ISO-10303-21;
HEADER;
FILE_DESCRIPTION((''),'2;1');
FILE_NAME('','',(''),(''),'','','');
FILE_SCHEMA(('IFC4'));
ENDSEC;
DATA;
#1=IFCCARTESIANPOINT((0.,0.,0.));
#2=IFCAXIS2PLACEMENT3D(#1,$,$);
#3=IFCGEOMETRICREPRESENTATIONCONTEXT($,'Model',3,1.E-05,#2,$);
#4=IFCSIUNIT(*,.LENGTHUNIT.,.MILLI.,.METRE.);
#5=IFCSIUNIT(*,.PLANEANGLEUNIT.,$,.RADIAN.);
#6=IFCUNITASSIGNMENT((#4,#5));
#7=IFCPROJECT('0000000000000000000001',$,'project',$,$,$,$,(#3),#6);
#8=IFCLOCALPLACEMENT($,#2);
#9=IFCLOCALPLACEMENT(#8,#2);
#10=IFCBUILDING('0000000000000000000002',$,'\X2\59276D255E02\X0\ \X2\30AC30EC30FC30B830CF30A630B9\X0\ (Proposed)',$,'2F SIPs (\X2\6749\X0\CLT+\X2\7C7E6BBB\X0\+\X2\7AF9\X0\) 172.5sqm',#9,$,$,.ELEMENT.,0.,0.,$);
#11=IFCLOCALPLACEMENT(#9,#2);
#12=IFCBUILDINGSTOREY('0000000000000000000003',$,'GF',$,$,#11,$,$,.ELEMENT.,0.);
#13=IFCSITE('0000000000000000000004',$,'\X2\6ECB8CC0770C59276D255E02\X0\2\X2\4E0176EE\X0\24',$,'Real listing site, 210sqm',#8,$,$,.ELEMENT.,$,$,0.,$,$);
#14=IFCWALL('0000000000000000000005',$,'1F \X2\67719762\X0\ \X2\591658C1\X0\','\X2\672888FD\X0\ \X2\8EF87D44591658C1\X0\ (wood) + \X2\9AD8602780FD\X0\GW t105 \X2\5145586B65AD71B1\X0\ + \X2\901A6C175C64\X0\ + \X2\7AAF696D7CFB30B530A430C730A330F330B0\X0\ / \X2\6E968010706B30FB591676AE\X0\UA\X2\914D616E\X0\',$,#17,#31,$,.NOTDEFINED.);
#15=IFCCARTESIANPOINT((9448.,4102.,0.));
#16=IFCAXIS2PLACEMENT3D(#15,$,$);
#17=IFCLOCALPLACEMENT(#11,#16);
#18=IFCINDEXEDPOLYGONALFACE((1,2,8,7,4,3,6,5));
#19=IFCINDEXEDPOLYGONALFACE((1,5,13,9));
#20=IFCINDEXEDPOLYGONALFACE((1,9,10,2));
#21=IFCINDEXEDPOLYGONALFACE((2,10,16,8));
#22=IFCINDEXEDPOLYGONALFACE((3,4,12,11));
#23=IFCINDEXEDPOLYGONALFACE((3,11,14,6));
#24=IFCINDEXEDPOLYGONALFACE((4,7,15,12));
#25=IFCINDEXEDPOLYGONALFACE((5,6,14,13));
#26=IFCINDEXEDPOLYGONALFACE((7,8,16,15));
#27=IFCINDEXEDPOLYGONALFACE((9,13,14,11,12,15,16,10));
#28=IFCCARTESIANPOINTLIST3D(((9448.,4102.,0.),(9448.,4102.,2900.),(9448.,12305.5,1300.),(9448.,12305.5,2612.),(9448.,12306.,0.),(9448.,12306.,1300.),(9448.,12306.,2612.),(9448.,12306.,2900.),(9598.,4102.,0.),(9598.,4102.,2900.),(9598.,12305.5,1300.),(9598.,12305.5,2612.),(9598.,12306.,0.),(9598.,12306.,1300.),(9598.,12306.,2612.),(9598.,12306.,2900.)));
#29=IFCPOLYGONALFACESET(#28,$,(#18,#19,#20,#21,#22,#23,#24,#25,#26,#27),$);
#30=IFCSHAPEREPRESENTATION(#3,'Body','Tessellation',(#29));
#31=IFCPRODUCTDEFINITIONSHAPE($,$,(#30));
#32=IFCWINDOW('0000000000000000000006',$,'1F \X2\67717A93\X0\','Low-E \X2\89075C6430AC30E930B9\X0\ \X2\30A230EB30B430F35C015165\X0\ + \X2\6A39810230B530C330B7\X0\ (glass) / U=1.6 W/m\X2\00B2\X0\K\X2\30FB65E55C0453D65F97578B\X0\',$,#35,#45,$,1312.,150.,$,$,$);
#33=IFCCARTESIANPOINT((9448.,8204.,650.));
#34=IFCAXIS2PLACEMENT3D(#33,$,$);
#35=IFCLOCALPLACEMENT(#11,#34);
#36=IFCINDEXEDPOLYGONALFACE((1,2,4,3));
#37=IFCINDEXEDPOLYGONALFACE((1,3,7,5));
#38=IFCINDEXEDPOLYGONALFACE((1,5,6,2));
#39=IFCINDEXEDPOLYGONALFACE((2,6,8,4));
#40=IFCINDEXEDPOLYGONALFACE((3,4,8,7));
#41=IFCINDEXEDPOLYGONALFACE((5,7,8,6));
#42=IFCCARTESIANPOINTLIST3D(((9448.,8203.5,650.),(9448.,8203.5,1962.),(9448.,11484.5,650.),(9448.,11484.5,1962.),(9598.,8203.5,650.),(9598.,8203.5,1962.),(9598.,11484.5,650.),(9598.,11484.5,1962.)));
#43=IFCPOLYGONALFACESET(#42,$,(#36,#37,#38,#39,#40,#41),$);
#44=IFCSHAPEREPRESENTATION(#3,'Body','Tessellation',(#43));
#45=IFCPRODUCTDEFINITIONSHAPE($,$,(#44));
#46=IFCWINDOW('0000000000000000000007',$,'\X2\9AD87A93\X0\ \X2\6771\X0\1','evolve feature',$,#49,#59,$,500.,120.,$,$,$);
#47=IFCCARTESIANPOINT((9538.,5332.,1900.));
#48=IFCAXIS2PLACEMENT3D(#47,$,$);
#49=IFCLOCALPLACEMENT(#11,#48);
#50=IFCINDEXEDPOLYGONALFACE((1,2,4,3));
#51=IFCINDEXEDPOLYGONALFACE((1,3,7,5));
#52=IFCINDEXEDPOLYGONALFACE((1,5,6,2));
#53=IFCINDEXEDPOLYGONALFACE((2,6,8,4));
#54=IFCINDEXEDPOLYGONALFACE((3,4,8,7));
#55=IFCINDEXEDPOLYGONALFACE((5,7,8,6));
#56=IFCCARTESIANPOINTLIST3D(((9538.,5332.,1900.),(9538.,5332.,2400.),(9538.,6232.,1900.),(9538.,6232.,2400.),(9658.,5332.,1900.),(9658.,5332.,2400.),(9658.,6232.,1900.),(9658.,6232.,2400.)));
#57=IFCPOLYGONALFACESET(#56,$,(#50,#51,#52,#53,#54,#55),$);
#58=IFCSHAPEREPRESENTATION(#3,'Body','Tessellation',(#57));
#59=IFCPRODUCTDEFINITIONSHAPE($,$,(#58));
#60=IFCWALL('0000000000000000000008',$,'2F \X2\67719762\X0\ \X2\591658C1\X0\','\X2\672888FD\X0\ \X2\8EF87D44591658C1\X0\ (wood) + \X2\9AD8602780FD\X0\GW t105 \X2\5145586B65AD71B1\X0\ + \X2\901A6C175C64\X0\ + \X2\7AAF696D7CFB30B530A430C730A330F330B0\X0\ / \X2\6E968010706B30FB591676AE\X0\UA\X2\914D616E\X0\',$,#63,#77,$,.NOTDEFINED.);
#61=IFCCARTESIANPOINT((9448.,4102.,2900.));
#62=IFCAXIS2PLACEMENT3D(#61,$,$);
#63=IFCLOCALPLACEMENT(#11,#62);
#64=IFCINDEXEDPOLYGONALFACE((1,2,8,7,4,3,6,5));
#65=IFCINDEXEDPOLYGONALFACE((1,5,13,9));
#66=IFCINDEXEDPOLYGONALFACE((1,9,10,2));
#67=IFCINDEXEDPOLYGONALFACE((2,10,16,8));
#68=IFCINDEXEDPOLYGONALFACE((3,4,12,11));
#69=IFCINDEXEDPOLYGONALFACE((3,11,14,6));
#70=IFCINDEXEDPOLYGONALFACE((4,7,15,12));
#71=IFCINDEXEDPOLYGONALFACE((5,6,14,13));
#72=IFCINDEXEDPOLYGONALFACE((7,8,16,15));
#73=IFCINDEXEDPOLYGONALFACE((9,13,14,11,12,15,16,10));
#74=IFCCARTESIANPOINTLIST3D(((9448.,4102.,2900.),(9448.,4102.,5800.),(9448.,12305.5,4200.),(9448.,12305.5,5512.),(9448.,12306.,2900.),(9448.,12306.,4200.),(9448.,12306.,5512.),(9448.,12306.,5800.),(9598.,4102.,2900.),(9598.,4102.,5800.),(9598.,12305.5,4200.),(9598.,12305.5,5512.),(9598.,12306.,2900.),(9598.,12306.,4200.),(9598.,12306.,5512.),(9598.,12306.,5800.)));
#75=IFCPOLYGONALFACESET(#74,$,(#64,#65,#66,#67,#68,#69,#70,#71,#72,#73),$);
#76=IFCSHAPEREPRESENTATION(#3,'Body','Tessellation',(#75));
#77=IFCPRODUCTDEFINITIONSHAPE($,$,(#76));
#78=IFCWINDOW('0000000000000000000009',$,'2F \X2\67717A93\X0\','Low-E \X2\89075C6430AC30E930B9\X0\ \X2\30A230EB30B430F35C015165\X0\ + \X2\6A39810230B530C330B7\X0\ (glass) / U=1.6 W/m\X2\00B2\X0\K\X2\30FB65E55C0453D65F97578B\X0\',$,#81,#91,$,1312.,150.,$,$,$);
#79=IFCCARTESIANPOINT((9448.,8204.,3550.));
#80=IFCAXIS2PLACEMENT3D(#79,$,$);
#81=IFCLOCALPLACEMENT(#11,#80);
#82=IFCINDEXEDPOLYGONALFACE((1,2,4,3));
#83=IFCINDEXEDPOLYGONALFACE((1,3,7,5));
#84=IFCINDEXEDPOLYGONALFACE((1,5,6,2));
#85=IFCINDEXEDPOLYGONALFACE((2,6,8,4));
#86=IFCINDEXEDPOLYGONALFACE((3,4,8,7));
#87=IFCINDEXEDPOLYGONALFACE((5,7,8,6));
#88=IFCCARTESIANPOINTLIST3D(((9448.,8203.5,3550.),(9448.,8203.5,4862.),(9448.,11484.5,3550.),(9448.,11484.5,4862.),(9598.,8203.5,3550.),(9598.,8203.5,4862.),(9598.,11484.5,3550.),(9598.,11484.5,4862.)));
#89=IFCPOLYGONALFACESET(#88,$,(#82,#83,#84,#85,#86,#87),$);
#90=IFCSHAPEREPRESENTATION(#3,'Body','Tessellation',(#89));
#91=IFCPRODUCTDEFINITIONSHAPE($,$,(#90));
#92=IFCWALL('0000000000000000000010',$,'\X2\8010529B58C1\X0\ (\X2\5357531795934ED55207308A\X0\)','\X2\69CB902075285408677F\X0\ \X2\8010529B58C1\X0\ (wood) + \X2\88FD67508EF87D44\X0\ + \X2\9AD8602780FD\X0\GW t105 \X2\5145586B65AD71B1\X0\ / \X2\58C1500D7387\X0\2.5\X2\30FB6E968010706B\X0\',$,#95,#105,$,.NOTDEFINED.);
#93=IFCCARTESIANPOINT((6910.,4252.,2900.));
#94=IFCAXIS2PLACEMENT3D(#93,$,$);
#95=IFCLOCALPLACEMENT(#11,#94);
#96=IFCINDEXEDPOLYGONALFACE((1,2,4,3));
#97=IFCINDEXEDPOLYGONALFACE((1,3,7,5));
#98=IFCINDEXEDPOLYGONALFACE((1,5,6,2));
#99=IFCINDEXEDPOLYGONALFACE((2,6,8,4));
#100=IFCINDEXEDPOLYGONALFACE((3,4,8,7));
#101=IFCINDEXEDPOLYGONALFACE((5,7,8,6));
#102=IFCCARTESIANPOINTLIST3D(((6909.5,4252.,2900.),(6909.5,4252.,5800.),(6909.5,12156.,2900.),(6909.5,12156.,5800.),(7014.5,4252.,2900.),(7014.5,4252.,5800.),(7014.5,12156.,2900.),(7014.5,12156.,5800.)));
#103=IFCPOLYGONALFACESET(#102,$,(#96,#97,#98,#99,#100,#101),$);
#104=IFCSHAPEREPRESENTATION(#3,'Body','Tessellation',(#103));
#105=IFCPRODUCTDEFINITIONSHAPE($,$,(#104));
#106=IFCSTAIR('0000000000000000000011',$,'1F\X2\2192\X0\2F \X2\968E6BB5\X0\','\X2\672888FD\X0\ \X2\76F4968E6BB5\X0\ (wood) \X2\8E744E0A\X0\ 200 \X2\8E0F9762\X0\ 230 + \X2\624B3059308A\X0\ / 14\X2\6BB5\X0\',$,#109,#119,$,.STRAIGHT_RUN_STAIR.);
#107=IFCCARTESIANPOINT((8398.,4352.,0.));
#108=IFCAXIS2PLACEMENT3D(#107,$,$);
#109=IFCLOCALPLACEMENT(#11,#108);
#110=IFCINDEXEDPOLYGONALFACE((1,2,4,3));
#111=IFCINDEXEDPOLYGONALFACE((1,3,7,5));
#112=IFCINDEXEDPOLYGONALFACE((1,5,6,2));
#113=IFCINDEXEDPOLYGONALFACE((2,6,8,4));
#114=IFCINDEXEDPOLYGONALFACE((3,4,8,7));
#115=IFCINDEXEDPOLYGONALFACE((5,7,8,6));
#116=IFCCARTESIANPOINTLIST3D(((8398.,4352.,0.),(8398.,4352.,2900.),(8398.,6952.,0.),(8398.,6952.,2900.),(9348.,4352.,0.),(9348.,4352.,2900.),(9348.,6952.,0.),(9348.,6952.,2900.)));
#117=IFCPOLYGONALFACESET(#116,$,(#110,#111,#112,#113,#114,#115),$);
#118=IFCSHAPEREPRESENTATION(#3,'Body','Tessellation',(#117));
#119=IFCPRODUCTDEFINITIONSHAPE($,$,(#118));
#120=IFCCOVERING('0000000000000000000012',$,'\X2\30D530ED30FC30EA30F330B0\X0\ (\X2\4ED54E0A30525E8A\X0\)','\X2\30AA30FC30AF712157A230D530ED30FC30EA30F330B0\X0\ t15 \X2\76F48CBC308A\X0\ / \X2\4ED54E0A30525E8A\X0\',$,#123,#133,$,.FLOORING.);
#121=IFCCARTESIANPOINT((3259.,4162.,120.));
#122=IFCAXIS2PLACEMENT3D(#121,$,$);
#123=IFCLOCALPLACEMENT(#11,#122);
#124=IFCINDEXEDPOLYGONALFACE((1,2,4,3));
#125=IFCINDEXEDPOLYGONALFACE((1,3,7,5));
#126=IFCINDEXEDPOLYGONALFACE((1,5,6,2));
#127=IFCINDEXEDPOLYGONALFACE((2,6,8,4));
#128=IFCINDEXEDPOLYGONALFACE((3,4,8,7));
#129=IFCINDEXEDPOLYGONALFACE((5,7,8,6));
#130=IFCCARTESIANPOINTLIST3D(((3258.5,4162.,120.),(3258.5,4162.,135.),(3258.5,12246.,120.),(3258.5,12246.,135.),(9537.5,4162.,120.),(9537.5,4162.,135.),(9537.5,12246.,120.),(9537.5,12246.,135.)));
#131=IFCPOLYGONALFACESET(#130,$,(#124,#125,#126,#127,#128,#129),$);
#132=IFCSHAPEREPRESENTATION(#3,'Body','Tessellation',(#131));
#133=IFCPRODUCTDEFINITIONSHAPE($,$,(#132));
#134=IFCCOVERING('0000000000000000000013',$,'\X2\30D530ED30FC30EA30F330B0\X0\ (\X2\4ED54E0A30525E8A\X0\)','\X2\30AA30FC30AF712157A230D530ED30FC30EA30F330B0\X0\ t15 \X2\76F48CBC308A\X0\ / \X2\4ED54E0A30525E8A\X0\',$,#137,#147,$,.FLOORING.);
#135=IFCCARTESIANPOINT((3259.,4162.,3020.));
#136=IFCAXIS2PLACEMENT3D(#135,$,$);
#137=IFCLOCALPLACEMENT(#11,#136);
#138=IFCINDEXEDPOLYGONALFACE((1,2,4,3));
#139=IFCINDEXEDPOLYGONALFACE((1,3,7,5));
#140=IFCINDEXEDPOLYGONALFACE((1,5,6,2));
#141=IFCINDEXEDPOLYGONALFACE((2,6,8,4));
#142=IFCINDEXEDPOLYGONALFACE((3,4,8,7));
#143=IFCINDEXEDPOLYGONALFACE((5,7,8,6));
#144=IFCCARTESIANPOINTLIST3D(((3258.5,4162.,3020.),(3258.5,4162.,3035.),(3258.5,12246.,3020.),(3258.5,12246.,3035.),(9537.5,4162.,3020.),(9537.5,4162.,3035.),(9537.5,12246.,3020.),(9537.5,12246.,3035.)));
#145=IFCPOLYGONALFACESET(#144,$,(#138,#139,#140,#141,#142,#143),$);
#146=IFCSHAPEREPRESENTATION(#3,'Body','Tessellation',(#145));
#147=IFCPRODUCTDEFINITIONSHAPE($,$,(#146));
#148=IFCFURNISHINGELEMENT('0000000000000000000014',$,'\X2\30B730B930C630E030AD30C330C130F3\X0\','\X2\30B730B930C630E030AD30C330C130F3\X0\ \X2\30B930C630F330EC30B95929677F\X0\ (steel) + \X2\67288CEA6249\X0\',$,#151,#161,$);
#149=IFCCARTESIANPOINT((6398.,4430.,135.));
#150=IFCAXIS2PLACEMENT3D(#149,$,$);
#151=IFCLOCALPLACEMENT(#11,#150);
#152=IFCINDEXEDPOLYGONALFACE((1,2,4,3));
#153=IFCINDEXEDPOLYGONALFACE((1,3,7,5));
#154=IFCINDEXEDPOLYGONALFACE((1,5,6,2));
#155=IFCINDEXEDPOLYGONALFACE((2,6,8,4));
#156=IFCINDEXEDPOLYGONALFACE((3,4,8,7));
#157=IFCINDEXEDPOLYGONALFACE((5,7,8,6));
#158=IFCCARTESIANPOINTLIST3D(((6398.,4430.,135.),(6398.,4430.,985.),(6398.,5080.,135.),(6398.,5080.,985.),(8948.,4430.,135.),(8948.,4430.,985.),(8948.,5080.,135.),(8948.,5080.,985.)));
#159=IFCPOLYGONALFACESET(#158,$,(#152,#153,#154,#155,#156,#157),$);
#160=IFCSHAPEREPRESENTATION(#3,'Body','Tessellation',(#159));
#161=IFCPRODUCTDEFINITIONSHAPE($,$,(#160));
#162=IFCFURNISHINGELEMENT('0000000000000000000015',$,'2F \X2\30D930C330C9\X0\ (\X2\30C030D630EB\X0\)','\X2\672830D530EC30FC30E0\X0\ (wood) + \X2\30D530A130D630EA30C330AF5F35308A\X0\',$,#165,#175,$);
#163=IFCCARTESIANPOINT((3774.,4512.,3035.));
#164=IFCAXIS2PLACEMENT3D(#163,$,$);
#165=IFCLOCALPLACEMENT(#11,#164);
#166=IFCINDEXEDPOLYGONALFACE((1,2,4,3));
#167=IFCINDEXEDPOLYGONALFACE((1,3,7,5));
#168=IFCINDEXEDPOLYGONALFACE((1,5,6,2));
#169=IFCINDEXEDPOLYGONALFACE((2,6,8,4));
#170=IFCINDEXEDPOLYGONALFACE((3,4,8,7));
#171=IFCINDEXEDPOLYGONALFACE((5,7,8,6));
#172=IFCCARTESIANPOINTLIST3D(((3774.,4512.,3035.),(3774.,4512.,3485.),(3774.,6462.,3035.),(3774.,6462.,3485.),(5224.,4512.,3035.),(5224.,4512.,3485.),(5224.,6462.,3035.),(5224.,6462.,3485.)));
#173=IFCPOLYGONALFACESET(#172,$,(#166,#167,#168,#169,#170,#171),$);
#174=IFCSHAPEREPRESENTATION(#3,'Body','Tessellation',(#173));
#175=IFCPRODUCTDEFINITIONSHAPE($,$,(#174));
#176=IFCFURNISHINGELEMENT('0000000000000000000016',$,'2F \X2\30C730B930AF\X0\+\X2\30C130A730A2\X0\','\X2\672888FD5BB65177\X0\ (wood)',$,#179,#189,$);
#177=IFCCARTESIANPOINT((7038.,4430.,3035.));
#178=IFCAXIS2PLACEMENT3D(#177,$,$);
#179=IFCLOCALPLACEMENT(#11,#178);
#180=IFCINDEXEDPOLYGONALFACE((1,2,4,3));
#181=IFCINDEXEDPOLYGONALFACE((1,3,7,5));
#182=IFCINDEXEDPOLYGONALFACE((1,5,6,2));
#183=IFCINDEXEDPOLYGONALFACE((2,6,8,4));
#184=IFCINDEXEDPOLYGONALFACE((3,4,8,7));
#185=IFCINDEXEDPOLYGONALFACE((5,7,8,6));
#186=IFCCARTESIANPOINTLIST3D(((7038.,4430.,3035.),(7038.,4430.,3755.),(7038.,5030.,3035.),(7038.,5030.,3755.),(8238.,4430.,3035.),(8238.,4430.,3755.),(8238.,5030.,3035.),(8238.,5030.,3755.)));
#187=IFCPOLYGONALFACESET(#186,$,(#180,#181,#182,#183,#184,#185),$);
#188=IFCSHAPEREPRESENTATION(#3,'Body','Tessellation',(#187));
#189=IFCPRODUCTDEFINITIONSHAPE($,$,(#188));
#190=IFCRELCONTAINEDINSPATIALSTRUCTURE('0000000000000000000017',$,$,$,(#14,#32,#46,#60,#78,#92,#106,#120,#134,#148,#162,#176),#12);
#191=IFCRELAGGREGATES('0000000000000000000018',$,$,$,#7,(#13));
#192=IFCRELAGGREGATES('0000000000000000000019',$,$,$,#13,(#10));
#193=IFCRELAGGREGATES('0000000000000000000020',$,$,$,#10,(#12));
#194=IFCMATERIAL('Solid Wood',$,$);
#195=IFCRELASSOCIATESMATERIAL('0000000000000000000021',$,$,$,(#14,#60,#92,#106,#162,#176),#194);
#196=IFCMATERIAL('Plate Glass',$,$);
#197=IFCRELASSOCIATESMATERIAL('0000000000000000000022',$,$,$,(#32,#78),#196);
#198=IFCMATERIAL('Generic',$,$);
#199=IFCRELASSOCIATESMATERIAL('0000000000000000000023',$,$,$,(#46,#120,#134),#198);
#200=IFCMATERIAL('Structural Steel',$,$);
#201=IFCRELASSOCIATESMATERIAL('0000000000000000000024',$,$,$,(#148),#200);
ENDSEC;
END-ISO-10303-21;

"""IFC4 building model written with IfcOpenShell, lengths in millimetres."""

from ifc_helpers import new_model, si_unit, frame, frame_2d, origin, place, context, project, spatial, rectangle, extrude, material, element, fill, save


model = new_model("IFC4")

# Units and contexts
model_context = context("Model", 3, precision=1e-05, world=origin())
ifc_project = project(units=[si_unit("LENGTHUNIT", "METRE", prefix="MILLI"), si_unit("PLANEANGLEUNIT", "RADIAN")], contexts=[model_context])

# Site, building, storey
site_placement = place(None, origin())
site = spatial("IfcSite", under=ifc_project, at=site_placement, Name="滋賀県大津市2丁目24", ObjectType="Real listing site, 210sqm", CompositionType="ELEMENT", RefElevation=0.0)
building_placement = place(site_placement, origin())
building = spatial("IfcBuilding", under=site, at=building_placement, Name="大津市 ガレージハウス (Proposed)", ObjectType="2F SIPs (杉CLT+籾殻+竹) 172.5sqm", CompositionType="ELEMENT", ElevationOfRefHeight=0.0, ElevationOfTerrain=0.0)
storey_placement = place(building_placement, origin())
storey = spatial("IfcBuildingStorey", under=building, at=storey_placement, Name="GF", CompositionType="ELEMENT", Elevation=0.0)

# Shared definitions
ifc_material_1 = material(Name="Solid Wood")

# Wall, openings, windows
wall_1_placement = place(storey_placement, frame((9448.0, 4102.0, 0.0)))
wall_1 = element("IfcWall", 1, at=wall_1_placement, inside=storey, material=ifc_material_1, Name="1F 東面 外壁", Description="木製 軸組外壁 (wood) + 高性能GW t105 充填断熱 + 通気層 + 窯業系サイディング / 準耐火・外皮UA配慮", PredefinedType="NOTDEFINED", context=model_context, shape_type="SweptSolid", body=[
    extrude(rectangle(XDim=150.0, YDim=8204.0, at=frame_2d((75.0, 4102.0))), frame((9448.0, 4102.0, 0.0)), (0.0, 0.0, 1.0), 2900.0),
])
opening_1_placement = place(storey_placement, frame((9448.0, 8204.0, 650.0)))
opening_1 = element("IfcOpeningElement", 2, at=opening_1_placement, cuts=wall_1, PredefinedType="NOTDEFINED", context=model_context, shape_type="SweptSolid", body=[
    extrude(rectangle(XDim=150.0, YDim=3281.0, at=frame_2d((75.0, 1640.0))), frame((9448.0, 8204.0, 650.0)), (0.0, 0.0, 1.0), 1312.0),
])
opening_2_placement = place(storey_placement, frame((9538.0, 5332.0, 1900.0)))
opening_2 = element("IfcOpeningElement", 3, at=opening_2_placement, cuts=wall_1, PredefinedType="NOTDEFINED", context=model_context, shape_type="SweptSolid", body=[
    extrude(rectangle(XDim=120.0, YDim=900.0, at=frame_2d((60.0, 450.0))), frame((9538.0, 5332.0, 1900.0)), (0.0, 0.0, 1.0), 500.0),
])
ifc_material_2 = material(Name="Plate Glass")
window_1_placement = place(storey_placement, frame((9448.0, 8204.0, 650.0)))
window_1 = element("IfcWindow", 4, at=window_1_placement, inside=storey, material=ifc_material_2, Name="1F 東窓", Description="Low-E 複層ガラス アルゴン封入 + 樹脂サッシ (glass) / U=1.6 W/m²K・日射取得型", OverallHeight=1312.0, OverallWidth=150.0, context=model_context, shape_type="SweptSolid", body=[
    extrude(rectangle(XDim=150.0, YDim=3281.0, at=frame_2d((75.0, 1640.0))), frame((9448.0, 8204.0, 650.0)), (0.0, 0.0, 1.0), 1312.0),
])
fill(opening_1, window_1)
ifc_material_3 = material(Name="Generic")
window_2_placement = place(storey_placement, frame((9538.0, 5332.0, 1900.0)))
window_2 = element("IfcWindow", 5, at=window_2_placement, inside=storey, material=ifc_material_3, Name="高窓 東1", Description="evolve feature", OverallHeight=500.0, OverallWidth=120.0, context=model_context, shape_type="SweptSolid", body=[
    extrude(rectangle(XDim=120.0, YDim=900.0, at=frame_2d((60.0, 450.0))), frame((9538.0, 5332.0, 1900.0)), (0.0, 0.0, 1.0), 500.0),
])
fill(opening_2, window_2)

# Wall, opening, window
wall_2_placement = place(storey_placement, frame((9448.0, 4102.0, 2900.0)))
wall_2 = element("IfcWall", 6, at=wall_2_placement, inside=storey, material=ifc_material_1, Name="2F 東面 外壁", Description="木製 軸組外壁 (wood) + 高性能GW t105 充填断熱 + 通気層 + 窯業系サイディング / 準耐火・外皮UA配慮", PredefinedType="NOTDEFINED", context=model_context, shape_type="SweptSolid", body=[
    extrude(rectangle(XDim=150.0, YDim=8204.0, at=frame_2d((75.0, 4102.0))), frame((9448.0, 4102.0, 2900.0)), (0.0, 0.0, 1.0), 2900.0),
])
opening_3_placement = place(storey_placement, frame((9448.0, 8204.0, 3550.0)))
opening_3 = element("IfcOpeningElement", 7, at=opening_3_placement, cuts=wall_2, PredefinedType="NOTDEFINED", context=model_context, shape_type="SweptSolid", body=[
    extrude(rectangle(XDim=150.0, YDim=3281.0, at=frame_2d((75.0, 1640.0))), frame((9448.0, 8204.0, 3550.0)), (0.0, 0.0, 1.0), 1312.0),
])
window_3_placement = place(storey_placement, frame((9448.0, 8204.0, 3550.0)))
window_3 = element("IfcWindow", 8, at=window_3_placement, inside=storey, material=ifc_material_2, Name="2F 東窓", Description="Low-E 複層ガラス アルゴン封入 + 樹脂サッシ (glass) / U=1.6 W/m²K・日射取得型", OverallHeight=1312.0, OverallWidth=150.0, context=model_context, shape_type="SweptSolid", body=[
    extrude(rectangle(XDim=150.0, YDim=3281.0, at=frame_2d((75.0, 1640.0))), frame((9448.0, 8204.0, 3550.0)), (0.0, 0.0, 1.0), 1312.0),
])
fill(opening_3, window_3)

# Wall
wall_3_placement = place(storey_placement, frame((6910.0, 4252.0, 2900.0)))
element("IfcWall", 9, at=wall_3_placement, inside=storey, material=ifc_material_1, Name="耐力壁 (南北間仕切り)", Description="構造用合板 耐力壁 (wood) + 製材軸組 + 高性能GW t105 充填断熱 / 壁倍率2.5・準耐火", PredefinedType="NOTDEFINED", context=model_context, shape_type="SweptSolid", body=[
    extrude(rectangle(XDim=105.0, YDim=7904.0, at=frame_2d((52.0, 3952.0))), frame((6910.0, 4252.0, 2900.0)), (0.0, 0.0, 1.0), 2900.0),
])

# Stair
stair_placement = place(storey_placement, frame((8398.0, 4352.0, 0.0)))
element("IfcStair", 10, at=stair_placement, inside=storey, material=ifc_material_1, Name="1F→2F 階段", Description="木製 直階段 (wood) 蹴上 200 踏面 230 + 手すり / 14段", PredefinedType="STRAIGHT_RUN_STAIR", context=model_context, shape_type="SweptSolid", body=[
    extrude(rectangle(XDim=950.0, YDim=2600.0, at=frame_2d((475.0, 1300.0))), frame((8398.0, 4352.0, 0.0)), (0.0, 0.0, 1.0), 2900.0),
])

# Coverings
covering_1_placement = place(storey_placement, frame((3259.0, 4162.0, 120.0)))
element("IfcCovering", 11, at=covering_1_placement, inside=storey, material=ifc_material_3, Name="フローリング (仕上げ床)", Description="オーク無垢フローリング t15 直貼り / 仕上げ床", PredefinedType="FLOORING", context=model_context, shape_type="SweptSolid", body=[
    extrude(rectangle(XDim=6279.0, YDim=8084.0, at=frame_2d((3139.0, 4042.0))), frame((3259.0, 4162.0, 120.0)), (0.0, 0.0, 1.0), 15.0),
])
covering_2_placement = place(storey_placement, frame((3259.0, 4162.0, 3020.0)))
element("IfcCovering", 12, at=covering_2_placement, inside=storey, material=ifc_material_3, Name="フローリング (仕上げ床)", Description="オーク無垢フローリング t15 直貼り / 仕上げ床", PredefinedType="FLOORING", context=model_context, shape_type="SweptSolid", body=[
    extrude(rectangle(XDim=6279.0, YDim=8084.0, at=frame_2d((3139.0, 4042.0))), frame((3259.0, 4162.0, 3020.0)), (0.0, 0.0, 1.0), 15.0),
])

# Furnishing elements
ifc_material_4 = material(Name="Structural Steel")
furnishing_1_placement = place(storey_placement, frame((6398.0, 4430.0, 135.0)))
element("IfcFurnishingElement", 13, at=furnishing_1_placement, inside=storey, material=ifc_material_4, Name="システムキッチン", Description="システムキッチン ステンレス天板 (steel) + 木質扉", context=model_context, shape_type="SweptSolid", body=[
    extrude(rectangle(XDim=2550.0, YDim=650.0, at=frame_2d((1275.0, 325.0))), frame((6398.0, 4430.0, 135.0)), (0.0, 0.0, 1.0), 850.0),
])
furnishing_2_placement = place(storey_placement, frame((3774.0, 4512.0, 3035.0)))
element("IfcFurnishingElement", 14, at=furnishing_2_placement, inside=storey, material=ifc_material_1, Name="2F ベッド (ダブル)", Description="木フレーム (wood) + ファブリック張り", context=model_context, shape_type="SweptSolid", body=[
    extrude(rectangle(XDim=1450.0, YDim=1950.0, at=frame_2d((725.0, 975.0))), frame((3774.0, 4512.0, 3035.0)), (0.0, 0.0, 1.0), 450.0),
])
furnishing_3_placement = place(storey_placement, frame((7038.0, 4430.0, 3035.0)))
element("IfcFurnishingElement", 15, at=furnishing_3_placement, inside=storey, material=ifc_material_1, Name="2F デスク+チェア", Description="木製家具 (wood)", context=model_context, shape_type="SweptSolid", body=[
    extrude(rectangle(XDim=1200.0, YDim=600.0, at=frame_2d((600.0, 300.0))), frame((7038.0, 4430.0, 3035.0)), (0.0, 0.0, 1.0), 720.0),
])

save(model, "model.ifc")
